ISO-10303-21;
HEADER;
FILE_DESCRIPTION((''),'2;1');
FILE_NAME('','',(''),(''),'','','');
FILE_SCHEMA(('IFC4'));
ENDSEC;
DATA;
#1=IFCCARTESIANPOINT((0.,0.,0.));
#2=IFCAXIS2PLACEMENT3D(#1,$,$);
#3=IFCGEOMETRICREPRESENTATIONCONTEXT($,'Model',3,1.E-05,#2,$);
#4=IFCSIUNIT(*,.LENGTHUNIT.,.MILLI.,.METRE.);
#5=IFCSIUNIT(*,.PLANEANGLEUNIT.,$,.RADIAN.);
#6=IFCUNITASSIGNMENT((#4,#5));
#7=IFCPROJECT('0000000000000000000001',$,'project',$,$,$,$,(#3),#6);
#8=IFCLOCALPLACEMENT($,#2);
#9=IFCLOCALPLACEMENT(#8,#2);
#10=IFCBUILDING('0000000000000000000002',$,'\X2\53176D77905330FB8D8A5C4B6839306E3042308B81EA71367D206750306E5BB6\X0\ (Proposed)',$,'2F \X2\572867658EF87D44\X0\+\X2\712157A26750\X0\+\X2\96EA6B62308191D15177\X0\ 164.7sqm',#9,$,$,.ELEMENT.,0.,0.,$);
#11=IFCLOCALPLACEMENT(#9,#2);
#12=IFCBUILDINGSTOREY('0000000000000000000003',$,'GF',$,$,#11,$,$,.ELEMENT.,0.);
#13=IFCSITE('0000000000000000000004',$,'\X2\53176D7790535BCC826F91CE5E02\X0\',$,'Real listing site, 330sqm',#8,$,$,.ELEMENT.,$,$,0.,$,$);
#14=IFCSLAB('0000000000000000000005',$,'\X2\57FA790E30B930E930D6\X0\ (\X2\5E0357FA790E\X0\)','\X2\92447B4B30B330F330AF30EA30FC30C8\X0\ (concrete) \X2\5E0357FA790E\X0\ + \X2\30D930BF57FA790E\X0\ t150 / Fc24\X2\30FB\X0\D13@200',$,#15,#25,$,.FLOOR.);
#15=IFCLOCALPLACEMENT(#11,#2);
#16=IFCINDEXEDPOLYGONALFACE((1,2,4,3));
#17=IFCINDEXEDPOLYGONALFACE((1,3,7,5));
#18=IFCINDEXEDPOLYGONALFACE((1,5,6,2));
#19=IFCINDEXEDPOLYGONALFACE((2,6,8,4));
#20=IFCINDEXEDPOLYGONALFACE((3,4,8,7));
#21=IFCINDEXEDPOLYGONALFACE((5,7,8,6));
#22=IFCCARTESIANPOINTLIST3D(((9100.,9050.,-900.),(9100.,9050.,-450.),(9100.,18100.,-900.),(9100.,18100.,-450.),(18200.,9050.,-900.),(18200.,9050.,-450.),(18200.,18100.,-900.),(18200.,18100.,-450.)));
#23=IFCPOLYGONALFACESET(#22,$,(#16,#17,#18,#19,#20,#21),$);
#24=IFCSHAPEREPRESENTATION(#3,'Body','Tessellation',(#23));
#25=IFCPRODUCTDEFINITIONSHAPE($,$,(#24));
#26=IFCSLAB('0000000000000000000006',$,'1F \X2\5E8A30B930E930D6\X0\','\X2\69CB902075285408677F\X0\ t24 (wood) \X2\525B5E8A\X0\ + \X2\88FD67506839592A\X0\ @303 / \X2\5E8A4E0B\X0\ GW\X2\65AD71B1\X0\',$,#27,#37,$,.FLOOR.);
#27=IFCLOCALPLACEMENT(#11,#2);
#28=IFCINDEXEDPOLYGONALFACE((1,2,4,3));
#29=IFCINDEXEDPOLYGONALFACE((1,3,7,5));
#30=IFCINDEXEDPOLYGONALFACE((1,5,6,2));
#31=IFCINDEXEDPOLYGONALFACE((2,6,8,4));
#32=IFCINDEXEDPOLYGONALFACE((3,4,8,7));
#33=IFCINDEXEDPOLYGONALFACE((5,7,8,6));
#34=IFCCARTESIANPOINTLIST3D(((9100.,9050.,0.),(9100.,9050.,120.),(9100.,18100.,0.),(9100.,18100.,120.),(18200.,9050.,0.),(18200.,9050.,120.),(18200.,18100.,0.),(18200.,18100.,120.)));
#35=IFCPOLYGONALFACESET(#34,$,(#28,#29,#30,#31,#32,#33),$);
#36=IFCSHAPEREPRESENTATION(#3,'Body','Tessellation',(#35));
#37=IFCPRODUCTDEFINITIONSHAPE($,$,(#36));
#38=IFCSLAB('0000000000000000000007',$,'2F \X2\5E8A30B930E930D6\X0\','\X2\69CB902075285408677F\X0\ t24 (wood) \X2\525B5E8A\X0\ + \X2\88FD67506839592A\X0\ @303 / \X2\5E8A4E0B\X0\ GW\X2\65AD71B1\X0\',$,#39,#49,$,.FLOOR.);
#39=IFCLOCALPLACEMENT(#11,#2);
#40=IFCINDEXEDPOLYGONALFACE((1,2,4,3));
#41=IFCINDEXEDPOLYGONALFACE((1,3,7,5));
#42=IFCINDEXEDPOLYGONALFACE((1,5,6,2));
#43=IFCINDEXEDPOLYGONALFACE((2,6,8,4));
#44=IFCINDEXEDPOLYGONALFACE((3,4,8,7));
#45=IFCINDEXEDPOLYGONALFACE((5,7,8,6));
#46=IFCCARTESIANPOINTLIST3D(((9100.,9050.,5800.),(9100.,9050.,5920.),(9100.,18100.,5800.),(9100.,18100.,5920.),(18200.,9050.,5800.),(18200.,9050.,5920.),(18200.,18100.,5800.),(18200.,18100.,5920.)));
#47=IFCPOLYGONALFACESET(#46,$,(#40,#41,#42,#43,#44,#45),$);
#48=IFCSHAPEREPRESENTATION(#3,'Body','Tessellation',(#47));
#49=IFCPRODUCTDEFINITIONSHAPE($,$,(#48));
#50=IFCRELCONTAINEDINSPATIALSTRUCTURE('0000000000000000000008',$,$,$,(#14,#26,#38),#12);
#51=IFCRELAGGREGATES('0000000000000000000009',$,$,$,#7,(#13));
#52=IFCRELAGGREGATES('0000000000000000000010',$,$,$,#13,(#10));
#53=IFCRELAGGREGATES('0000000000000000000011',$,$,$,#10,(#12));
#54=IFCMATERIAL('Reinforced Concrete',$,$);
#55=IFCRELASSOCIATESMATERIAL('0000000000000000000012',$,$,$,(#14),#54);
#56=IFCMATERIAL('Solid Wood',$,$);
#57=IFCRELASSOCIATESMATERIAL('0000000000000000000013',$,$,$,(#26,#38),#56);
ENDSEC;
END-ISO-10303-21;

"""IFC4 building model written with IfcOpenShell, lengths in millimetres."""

from ifc_helpers import new_model, si_unit, frame, frame_2d, origin, place, context, project, spatial, rectangle, extrude, material, element, save


model = new_model("IFC4")

# Units and contexts
model_context = context("Model", 3, precision=1e-05, world=origin())
ifc_project = project(units=[si_unit("LENGTHUNIT", "METRE", prefix="MILLI"), si_unit("PLANEANGLEUNIT", "RADIAN")], contexts=[model_context])

# Site, building, storey
site_placement = place(None, origin())
site = spatial("IfcSite", under=ifc_project, at=site_placement, Name="北海道富良野市", ObjectType="Real listing site, 330sqm", CompositionType="ELEMENT", RefElevation=0.0)
building_placement = place(site_placement, origin())
building = spatial("IfcBuilding", under=site, at=building_placement, Name="北海道・越屋根のある自然素材の家 (Proposed)", ObjectType="2F 在来軸組+無垢材+雪止め金具 164.7sqm", CompositionType="ELEMENT", ElevationOfRefHeight=0.0, ElevationOfTerrain=0.0)
storey_placement = place(building_placement, origin())
storey = spatial("IfcBuildingStorey", under=building, at=storey_placement, Name="GF", CompositionType="ELEMENT", Elevation=0.0)

# Shared definitions
ifc_material_1 = material(Name="Solid Wood")

# Slabs
ifc_material_2 = material(Name="Reinforced Concrete")
slab_1_placement = place(storey_placement, frame((4550.0, 4525.0, -450.0)))
element("IfcSlab", 1, at=slab_1_placement, inside=storey, material=ifc_material_2, Name="基礎スラブ (布基礎)", Description="鉄筋コンクリート (concrete) 布基礎 + ベタ基礎 t150 / Fc24・D13@200", PredefinedType="FLOOR", context=model_context, shape_type="SweptSolid", body=[
    extrude(rectangle(XDim=9100.0, YDim=9050.0, at=frame_2d((4550.0, 4525.0))), frame((4550.0, 4525.0, -450.0)), (0.0, 0.0, 1.0), 450.0),
])
slab_2_placement = place(storey_placement, frame((4550.0, 4525.0, 0.0)))
element("IfcSlab", 2, at=slab_2_placement, inside=storey, material=ifc_material_1, Name="1F 床スラブ", Description="構造用合板 t24 (wood) 剛床 + 製材根太 @303 / 床下 GW断熱", PredefinedType="FLOOR", context=model_context, shape_type="SweptSolid", body=[
    extrude(rectangle(XDim=9100.0, YDim=9050.0, at=frame_2d((4550.0, 4525.0))), frame((4550.0, 4525.0, 0.0)), (0.0, 0.0, 1.0), 120.0),
])
slab_3_placement = place(storey_placement, frame((4550.0, 4525.0, 2900.0)))
element("IfcSlab", 3, at=slab_3_placement, inside=storey, material=ifc_material_1, Name="2F 床スラブ", Description="構造用合板 t24 (wood) 剛床 + 製材根太 @303 / 床下 GW断熱", PredefinedType="FLOOR", context=model_context, shape_type="SweptSolid", body=[
    extrude(rectangle(XDim=9100.0, YDim=9050.0, at=frame_2d((4550.0, 4525.0))), frame((4550.0, 4525.0, 2900.0)), (0.0, 0.0, 1.0), 120.0),
])

save(model, "model.ifc")
